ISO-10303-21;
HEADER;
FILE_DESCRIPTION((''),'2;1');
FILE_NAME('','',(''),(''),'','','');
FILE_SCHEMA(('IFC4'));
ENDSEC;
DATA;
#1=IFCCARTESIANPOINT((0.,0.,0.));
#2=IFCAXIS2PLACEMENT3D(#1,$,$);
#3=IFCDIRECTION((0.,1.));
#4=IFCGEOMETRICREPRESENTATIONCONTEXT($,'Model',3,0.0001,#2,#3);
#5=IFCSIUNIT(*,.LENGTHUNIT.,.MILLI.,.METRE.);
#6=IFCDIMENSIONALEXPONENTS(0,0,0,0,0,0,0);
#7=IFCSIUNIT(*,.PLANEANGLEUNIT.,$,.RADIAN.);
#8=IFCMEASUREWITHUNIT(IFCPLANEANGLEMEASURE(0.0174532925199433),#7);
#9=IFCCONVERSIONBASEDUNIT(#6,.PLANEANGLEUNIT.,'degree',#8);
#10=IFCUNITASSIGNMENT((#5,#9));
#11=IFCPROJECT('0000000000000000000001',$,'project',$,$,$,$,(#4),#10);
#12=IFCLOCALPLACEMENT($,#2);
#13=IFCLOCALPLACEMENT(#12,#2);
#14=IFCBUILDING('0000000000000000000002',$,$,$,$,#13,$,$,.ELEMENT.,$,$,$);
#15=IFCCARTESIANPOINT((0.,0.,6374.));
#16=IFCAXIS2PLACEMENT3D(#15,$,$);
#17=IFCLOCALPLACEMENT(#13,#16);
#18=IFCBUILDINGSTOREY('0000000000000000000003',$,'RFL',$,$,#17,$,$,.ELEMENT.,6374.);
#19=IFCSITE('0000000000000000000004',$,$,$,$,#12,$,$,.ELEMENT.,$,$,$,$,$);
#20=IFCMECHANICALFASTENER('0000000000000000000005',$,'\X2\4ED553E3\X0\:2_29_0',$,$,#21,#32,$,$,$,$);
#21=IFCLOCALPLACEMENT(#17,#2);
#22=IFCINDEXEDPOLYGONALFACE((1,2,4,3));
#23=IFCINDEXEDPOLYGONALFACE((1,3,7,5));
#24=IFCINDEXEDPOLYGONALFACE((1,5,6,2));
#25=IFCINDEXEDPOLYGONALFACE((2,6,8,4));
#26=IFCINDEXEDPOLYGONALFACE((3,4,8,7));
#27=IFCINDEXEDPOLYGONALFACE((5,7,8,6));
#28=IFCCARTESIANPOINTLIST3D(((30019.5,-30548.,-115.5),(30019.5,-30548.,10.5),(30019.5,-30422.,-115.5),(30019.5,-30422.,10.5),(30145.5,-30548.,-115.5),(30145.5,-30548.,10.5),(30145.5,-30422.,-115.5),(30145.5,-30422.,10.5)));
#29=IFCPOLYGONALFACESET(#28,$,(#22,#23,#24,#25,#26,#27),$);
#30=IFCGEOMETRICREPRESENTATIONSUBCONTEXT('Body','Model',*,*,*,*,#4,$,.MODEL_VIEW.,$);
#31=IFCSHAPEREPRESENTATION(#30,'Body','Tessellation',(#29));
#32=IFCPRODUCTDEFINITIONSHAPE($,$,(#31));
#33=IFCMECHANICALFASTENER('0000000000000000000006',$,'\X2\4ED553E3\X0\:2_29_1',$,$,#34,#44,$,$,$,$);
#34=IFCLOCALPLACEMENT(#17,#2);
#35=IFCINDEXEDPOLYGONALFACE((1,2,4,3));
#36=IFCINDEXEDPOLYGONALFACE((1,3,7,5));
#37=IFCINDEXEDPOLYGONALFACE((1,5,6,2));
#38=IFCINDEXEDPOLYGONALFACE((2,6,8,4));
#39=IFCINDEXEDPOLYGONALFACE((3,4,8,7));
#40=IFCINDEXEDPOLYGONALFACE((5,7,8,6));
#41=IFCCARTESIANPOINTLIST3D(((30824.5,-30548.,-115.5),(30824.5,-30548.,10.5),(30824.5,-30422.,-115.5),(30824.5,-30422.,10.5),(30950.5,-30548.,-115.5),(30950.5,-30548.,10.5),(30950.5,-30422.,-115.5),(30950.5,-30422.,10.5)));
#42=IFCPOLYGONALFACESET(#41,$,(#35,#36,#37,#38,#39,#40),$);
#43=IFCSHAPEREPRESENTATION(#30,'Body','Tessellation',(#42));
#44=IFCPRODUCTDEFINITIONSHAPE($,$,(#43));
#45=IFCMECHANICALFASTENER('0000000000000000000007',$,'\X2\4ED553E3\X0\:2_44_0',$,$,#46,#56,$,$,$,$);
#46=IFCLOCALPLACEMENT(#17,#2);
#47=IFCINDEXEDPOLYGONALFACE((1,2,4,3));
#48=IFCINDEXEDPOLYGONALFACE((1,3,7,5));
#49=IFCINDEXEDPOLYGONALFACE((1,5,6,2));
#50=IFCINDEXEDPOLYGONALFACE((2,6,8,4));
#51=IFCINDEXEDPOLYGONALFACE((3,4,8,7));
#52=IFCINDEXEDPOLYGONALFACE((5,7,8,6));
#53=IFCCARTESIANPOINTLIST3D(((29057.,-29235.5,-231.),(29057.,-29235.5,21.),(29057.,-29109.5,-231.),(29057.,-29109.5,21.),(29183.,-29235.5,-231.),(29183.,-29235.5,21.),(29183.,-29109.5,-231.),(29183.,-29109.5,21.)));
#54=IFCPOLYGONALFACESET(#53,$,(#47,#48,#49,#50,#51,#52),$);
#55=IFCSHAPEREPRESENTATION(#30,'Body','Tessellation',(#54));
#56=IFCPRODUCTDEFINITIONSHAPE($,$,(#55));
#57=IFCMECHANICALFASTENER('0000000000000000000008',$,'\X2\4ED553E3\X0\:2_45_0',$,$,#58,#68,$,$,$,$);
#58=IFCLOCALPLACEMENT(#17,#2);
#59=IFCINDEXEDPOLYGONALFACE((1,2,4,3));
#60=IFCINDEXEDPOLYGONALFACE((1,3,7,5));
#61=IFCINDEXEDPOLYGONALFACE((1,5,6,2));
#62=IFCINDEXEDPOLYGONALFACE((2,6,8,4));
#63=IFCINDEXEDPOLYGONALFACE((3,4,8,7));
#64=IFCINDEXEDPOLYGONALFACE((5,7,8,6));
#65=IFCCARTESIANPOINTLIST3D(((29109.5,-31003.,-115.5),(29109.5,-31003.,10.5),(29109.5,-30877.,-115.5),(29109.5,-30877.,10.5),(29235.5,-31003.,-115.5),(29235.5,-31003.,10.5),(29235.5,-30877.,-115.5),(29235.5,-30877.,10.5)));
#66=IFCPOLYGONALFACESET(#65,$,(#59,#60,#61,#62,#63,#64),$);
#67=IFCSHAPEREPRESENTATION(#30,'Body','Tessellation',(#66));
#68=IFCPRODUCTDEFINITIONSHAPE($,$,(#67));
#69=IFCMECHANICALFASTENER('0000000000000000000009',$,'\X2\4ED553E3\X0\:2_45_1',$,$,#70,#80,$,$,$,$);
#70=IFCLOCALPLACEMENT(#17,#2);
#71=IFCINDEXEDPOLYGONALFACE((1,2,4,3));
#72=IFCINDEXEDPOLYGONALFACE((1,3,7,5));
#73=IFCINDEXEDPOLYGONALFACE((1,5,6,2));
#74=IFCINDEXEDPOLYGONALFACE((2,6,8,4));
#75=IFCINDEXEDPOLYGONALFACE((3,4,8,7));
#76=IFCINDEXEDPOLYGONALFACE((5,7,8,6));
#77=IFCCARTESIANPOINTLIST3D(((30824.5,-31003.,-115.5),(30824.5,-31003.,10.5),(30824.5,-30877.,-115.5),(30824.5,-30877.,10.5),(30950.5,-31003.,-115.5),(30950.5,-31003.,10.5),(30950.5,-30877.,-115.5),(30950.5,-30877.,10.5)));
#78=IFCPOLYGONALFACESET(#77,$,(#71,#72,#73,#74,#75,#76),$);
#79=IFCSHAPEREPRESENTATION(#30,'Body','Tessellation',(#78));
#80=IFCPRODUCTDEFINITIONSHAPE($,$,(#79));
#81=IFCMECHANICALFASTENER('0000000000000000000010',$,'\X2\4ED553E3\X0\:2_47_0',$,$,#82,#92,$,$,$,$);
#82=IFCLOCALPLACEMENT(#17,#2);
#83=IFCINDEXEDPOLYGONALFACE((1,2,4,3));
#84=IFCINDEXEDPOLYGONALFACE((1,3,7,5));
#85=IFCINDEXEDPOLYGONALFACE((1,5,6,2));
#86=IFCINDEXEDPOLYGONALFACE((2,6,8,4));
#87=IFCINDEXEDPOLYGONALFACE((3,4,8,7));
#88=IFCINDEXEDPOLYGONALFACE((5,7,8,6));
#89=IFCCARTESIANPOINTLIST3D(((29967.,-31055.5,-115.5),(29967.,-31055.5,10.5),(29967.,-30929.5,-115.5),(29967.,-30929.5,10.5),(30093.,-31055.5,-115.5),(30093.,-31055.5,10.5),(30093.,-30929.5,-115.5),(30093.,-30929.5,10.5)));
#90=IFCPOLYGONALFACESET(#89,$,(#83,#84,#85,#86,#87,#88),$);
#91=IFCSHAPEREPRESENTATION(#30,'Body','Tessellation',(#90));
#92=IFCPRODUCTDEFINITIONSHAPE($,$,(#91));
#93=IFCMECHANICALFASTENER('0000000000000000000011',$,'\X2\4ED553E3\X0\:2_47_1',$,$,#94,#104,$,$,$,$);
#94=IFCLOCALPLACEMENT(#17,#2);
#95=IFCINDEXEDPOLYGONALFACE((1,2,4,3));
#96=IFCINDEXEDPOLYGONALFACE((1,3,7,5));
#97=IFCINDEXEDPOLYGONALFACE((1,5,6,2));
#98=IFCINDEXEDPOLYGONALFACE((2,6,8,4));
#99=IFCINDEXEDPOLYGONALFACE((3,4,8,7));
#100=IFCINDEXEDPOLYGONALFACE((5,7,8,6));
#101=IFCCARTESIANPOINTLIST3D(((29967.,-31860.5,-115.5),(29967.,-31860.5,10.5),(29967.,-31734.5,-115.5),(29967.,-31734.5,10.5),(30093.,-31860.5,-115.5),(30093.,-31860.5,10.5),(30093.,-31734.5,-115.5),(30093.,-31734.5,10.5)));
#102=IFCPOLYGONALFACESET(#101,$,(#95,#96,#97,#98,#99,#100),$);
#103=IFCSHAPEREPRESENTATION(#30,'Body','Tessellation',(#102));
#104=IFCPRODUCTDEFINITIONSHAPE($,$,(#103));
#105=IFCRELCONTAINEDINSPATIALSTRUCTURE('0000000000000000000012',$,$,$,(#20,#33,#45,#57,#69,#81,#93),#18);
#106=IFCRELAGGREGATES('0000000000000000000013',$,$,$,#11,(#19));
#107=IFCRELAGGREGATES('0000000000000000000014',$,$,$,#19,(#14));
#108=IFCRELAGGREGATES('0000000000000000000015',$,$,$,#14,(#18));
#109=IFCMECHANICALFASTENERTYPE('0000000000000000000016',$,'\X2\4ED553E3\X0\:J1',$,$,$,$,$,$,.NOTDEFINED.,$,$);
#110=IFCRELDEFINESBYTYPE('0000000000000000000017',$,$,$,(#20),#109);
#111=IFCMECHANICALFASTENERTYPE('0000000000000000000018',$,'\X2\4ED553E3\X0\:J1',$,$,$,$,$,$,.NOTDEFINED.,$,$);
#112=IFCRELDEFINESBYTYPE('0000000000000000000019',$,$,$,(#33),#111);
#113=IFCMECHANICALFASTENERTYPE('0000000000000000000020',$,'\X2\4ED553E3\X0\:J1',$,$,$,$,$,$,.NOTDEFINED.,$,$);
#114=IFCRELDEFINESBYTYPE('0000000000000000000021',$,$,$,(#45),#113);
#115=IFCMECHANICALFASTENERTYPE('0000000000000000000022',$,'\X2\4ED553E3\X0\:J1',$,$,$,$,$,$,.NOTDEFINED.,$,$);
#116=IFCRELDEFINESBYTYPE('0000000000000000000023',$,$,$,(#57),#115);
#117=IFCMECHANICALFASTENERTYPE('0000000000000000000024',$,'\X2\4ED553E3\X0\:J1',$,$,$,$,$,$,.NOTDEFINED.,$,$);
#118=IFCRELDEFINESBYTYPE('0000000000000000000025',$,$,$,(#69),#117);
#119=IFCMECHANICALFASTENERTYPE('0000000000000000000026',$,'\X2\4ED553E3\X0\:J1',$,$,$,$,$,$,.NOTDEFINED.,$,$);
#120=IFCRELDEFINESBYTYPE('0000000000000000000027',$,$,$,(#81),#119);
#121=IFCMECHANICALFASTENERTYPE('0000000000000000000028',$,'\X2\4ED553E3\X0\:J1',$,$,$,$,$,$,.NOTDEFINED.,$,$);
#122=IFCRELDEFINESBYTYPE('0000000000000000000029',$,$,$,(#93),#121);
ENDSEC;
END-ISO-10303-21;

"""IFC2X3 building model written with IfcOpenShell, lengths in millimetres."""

from ifc_helpers import new_model, entity, si_unit, converted_unit, direction, frame, origin, origin_with_axes, origin_2d, place, context, subcontext, project, spatial, rectangle, extrude, type_object, element, save


model = new_model("IFC2X3")

# Units and contexts
model_context = context("Model", 3, precision=0.0001, world=origin(), true_north=direction((0.0, 1.0)))
body_context = subcontext(model_context, "Body", "Model", "MODEL_VIEW")
ifc_project = project(units=[si_unit("LENGTHUNIT", "METRE", prefix="MILLI"), converted_unit("PLANEANGLEUNIT", "degree", entity("IfcPlaneAngleMeasure", 0.0174532925199433), si_unit("PLANEANGLEUNIT", "RADIAN"), dimensions=[0, 0, 0, 0, 0, 0, 0])], contexts=[model_context])

# Site, building, storey
site_placement = place(None, origin())
site = spatial("IfcSite", under=ifc_project, at=site_placement, CompositionType="ELEMENT")
building_placement = place(site_placement, origin())
building = spatial("IfcBuilding", under=site, at=building_placement, CompositionType="ELEMENT")
storey_placement = place(building_placement, frame((0.0, 0.0, 6374.0)))
storey = spatial("IfcBuildingStorey", under=building, at=storey_placement, Name="RFL", CompositionType="ELEMENT", Elevation=6374.0)

# Mechanical fasteners
mechanical_fastener_type_1 = type_object("IfcMechanicalFastenerType", Name="仕口:J1")
mechanical_fastener_1_placement = place(storey_placement, frame((30082.5, -30485.0, -115.5)))
element("IfcMechanicalFastener", 1, at=mechanical_fastener_1_placement, inside=storey, type_object=mechanical_fastener_type_1, Name="仕口:2_29_0", context=body_context, shape_type="SweptSolid", body=[
    extrude(rectangle(XDim=126.0, YDim=126.0, at=origin_2d()), origin_with_axes(), (0.0, 0.0, 1.0), 126.0),
])
mechanical_fastener_type_2 = type_object("IfcMechanicalFastenerType", Name="仕口:J1")
mechanical_fastener_2_placement = place(storey_placement, frame((30887.5, -30485.0, -115.5)))
element("IfcMechanicalFastener", 2, at=mechanical_fastener_2_placement, inside=storey, type_object=mechanical_fastener_type_2, Name="仕口:2_29_1", context=body_context, shape_type="SweptSolid", body=[
    extrude(rectangle(XDim=126.0, YDim=126.0, at=origin_2d()), origin_with_axes(), (0.0, 0.0, 1.0), 126.0),
])
mechanical_fastener_type_3 = type_object("IfcMechanicalFastenerType", Name="仕口:J1")
mechanical_fastener_3_placement = place(storey_placement, frame((29120.0, -29172.5, -231.0)))
element("IfcMechanicalFastener", 3, at=mechanical_fastener_3_placement, inside=storey, type_object=mechanical_fastener_type_3, Name="仕口:2_44_0", context=body_context, shape_type="SweptSolid", body=[
    extrude(rectangle(XDim=126.0, YDim=126.0, at=origin_2d()), origin_with_axes(), (0.0, 0.0, 1.0), 252.0),
])
mechanical_fastener_type_4 = type_object("IfcMechanicalFastenerType", Name="仕口:J1")
mechanical_fastener_4_placement = place(storey_placement, frame((29172.5, -30940.0, -115.5)))
element("IfcMechanicalFastener", 4, at=mechanical_fastener_4_placement, inside=storey, type_object=mechanical_fastener_type_4, Name="仕口:2_45_0", context=body_context, shape_type="SweptSolid", body=[
    extrude(rectangle(XDim=126.0, YDim=126.0, at=origin_2d()), origin_with_axes(), (0.0, 0.0, 1.0), 126.0),
])
mechanical_fastener_type_5 = type_object("IfcMechanicalFastenerType", Name="仕口:J1")
mechanical_fastener_5_placement = place(storey_placement, frame((30887.5, -30940.0, -115.5)))
element("IfcMechanicalFastener", 5, at=mechanical_fastener_5_placement, inside=storey, type_object=mechanical_fastener_type_5, Name="仕口:2_45_1", context=body_context, shape_type="SweptSolid", body=[
    extrude(rectangle(XDim=126.0, YDim=126.0, at=origin_2d()), origin_with_axes(), (0.0, 0.0, 1.0), 126.0),
])
mechanical_fastener_type_6 = type_object("IfcMechanicalFastenerType", Name="仕口:J1")
mechanical_fastener_6_placement = place(storey_placement, frame((30030.0, -30992.5, -115.5)))
element("IfcMechanicalFastener", 6, at=mechanical_fastener_6_placement, inside=storey, type_object=mechanical_fastener_type_6, Name="仕口:2_47_0", context=body_context, shape_type="SweptSolid", body=[
    extrude(rectangle(XDim=126.0, YDim=126.0, at=origin_2d()), origin_with_axes(), (0.0, 0.0, 1.0), 126.0),
])
mechanical_fastener_type_7 = type_object("IfcMechanicalFastenerType", Name="仕口:J1")
mechanical_fastener_7_placement = place(storey_placement, frame((30030.0, -31797.5, -115.5)))
element("IfcMechanicalFastener", 7, at=mechanical_fastener_7_placement, inside=storey, type_object=mechanical_fastener_type_7, Name="仕口:2_47_1", context=body_context, shape_type="SweptSolid", body=[
    extrude(rectangle(XDim=126.0, YDim=126.0, at=origin_2d()), origin_with_axes(), (0.0, 0.0, 1.0), 126.0),
])

save(model, "model.ifc")
